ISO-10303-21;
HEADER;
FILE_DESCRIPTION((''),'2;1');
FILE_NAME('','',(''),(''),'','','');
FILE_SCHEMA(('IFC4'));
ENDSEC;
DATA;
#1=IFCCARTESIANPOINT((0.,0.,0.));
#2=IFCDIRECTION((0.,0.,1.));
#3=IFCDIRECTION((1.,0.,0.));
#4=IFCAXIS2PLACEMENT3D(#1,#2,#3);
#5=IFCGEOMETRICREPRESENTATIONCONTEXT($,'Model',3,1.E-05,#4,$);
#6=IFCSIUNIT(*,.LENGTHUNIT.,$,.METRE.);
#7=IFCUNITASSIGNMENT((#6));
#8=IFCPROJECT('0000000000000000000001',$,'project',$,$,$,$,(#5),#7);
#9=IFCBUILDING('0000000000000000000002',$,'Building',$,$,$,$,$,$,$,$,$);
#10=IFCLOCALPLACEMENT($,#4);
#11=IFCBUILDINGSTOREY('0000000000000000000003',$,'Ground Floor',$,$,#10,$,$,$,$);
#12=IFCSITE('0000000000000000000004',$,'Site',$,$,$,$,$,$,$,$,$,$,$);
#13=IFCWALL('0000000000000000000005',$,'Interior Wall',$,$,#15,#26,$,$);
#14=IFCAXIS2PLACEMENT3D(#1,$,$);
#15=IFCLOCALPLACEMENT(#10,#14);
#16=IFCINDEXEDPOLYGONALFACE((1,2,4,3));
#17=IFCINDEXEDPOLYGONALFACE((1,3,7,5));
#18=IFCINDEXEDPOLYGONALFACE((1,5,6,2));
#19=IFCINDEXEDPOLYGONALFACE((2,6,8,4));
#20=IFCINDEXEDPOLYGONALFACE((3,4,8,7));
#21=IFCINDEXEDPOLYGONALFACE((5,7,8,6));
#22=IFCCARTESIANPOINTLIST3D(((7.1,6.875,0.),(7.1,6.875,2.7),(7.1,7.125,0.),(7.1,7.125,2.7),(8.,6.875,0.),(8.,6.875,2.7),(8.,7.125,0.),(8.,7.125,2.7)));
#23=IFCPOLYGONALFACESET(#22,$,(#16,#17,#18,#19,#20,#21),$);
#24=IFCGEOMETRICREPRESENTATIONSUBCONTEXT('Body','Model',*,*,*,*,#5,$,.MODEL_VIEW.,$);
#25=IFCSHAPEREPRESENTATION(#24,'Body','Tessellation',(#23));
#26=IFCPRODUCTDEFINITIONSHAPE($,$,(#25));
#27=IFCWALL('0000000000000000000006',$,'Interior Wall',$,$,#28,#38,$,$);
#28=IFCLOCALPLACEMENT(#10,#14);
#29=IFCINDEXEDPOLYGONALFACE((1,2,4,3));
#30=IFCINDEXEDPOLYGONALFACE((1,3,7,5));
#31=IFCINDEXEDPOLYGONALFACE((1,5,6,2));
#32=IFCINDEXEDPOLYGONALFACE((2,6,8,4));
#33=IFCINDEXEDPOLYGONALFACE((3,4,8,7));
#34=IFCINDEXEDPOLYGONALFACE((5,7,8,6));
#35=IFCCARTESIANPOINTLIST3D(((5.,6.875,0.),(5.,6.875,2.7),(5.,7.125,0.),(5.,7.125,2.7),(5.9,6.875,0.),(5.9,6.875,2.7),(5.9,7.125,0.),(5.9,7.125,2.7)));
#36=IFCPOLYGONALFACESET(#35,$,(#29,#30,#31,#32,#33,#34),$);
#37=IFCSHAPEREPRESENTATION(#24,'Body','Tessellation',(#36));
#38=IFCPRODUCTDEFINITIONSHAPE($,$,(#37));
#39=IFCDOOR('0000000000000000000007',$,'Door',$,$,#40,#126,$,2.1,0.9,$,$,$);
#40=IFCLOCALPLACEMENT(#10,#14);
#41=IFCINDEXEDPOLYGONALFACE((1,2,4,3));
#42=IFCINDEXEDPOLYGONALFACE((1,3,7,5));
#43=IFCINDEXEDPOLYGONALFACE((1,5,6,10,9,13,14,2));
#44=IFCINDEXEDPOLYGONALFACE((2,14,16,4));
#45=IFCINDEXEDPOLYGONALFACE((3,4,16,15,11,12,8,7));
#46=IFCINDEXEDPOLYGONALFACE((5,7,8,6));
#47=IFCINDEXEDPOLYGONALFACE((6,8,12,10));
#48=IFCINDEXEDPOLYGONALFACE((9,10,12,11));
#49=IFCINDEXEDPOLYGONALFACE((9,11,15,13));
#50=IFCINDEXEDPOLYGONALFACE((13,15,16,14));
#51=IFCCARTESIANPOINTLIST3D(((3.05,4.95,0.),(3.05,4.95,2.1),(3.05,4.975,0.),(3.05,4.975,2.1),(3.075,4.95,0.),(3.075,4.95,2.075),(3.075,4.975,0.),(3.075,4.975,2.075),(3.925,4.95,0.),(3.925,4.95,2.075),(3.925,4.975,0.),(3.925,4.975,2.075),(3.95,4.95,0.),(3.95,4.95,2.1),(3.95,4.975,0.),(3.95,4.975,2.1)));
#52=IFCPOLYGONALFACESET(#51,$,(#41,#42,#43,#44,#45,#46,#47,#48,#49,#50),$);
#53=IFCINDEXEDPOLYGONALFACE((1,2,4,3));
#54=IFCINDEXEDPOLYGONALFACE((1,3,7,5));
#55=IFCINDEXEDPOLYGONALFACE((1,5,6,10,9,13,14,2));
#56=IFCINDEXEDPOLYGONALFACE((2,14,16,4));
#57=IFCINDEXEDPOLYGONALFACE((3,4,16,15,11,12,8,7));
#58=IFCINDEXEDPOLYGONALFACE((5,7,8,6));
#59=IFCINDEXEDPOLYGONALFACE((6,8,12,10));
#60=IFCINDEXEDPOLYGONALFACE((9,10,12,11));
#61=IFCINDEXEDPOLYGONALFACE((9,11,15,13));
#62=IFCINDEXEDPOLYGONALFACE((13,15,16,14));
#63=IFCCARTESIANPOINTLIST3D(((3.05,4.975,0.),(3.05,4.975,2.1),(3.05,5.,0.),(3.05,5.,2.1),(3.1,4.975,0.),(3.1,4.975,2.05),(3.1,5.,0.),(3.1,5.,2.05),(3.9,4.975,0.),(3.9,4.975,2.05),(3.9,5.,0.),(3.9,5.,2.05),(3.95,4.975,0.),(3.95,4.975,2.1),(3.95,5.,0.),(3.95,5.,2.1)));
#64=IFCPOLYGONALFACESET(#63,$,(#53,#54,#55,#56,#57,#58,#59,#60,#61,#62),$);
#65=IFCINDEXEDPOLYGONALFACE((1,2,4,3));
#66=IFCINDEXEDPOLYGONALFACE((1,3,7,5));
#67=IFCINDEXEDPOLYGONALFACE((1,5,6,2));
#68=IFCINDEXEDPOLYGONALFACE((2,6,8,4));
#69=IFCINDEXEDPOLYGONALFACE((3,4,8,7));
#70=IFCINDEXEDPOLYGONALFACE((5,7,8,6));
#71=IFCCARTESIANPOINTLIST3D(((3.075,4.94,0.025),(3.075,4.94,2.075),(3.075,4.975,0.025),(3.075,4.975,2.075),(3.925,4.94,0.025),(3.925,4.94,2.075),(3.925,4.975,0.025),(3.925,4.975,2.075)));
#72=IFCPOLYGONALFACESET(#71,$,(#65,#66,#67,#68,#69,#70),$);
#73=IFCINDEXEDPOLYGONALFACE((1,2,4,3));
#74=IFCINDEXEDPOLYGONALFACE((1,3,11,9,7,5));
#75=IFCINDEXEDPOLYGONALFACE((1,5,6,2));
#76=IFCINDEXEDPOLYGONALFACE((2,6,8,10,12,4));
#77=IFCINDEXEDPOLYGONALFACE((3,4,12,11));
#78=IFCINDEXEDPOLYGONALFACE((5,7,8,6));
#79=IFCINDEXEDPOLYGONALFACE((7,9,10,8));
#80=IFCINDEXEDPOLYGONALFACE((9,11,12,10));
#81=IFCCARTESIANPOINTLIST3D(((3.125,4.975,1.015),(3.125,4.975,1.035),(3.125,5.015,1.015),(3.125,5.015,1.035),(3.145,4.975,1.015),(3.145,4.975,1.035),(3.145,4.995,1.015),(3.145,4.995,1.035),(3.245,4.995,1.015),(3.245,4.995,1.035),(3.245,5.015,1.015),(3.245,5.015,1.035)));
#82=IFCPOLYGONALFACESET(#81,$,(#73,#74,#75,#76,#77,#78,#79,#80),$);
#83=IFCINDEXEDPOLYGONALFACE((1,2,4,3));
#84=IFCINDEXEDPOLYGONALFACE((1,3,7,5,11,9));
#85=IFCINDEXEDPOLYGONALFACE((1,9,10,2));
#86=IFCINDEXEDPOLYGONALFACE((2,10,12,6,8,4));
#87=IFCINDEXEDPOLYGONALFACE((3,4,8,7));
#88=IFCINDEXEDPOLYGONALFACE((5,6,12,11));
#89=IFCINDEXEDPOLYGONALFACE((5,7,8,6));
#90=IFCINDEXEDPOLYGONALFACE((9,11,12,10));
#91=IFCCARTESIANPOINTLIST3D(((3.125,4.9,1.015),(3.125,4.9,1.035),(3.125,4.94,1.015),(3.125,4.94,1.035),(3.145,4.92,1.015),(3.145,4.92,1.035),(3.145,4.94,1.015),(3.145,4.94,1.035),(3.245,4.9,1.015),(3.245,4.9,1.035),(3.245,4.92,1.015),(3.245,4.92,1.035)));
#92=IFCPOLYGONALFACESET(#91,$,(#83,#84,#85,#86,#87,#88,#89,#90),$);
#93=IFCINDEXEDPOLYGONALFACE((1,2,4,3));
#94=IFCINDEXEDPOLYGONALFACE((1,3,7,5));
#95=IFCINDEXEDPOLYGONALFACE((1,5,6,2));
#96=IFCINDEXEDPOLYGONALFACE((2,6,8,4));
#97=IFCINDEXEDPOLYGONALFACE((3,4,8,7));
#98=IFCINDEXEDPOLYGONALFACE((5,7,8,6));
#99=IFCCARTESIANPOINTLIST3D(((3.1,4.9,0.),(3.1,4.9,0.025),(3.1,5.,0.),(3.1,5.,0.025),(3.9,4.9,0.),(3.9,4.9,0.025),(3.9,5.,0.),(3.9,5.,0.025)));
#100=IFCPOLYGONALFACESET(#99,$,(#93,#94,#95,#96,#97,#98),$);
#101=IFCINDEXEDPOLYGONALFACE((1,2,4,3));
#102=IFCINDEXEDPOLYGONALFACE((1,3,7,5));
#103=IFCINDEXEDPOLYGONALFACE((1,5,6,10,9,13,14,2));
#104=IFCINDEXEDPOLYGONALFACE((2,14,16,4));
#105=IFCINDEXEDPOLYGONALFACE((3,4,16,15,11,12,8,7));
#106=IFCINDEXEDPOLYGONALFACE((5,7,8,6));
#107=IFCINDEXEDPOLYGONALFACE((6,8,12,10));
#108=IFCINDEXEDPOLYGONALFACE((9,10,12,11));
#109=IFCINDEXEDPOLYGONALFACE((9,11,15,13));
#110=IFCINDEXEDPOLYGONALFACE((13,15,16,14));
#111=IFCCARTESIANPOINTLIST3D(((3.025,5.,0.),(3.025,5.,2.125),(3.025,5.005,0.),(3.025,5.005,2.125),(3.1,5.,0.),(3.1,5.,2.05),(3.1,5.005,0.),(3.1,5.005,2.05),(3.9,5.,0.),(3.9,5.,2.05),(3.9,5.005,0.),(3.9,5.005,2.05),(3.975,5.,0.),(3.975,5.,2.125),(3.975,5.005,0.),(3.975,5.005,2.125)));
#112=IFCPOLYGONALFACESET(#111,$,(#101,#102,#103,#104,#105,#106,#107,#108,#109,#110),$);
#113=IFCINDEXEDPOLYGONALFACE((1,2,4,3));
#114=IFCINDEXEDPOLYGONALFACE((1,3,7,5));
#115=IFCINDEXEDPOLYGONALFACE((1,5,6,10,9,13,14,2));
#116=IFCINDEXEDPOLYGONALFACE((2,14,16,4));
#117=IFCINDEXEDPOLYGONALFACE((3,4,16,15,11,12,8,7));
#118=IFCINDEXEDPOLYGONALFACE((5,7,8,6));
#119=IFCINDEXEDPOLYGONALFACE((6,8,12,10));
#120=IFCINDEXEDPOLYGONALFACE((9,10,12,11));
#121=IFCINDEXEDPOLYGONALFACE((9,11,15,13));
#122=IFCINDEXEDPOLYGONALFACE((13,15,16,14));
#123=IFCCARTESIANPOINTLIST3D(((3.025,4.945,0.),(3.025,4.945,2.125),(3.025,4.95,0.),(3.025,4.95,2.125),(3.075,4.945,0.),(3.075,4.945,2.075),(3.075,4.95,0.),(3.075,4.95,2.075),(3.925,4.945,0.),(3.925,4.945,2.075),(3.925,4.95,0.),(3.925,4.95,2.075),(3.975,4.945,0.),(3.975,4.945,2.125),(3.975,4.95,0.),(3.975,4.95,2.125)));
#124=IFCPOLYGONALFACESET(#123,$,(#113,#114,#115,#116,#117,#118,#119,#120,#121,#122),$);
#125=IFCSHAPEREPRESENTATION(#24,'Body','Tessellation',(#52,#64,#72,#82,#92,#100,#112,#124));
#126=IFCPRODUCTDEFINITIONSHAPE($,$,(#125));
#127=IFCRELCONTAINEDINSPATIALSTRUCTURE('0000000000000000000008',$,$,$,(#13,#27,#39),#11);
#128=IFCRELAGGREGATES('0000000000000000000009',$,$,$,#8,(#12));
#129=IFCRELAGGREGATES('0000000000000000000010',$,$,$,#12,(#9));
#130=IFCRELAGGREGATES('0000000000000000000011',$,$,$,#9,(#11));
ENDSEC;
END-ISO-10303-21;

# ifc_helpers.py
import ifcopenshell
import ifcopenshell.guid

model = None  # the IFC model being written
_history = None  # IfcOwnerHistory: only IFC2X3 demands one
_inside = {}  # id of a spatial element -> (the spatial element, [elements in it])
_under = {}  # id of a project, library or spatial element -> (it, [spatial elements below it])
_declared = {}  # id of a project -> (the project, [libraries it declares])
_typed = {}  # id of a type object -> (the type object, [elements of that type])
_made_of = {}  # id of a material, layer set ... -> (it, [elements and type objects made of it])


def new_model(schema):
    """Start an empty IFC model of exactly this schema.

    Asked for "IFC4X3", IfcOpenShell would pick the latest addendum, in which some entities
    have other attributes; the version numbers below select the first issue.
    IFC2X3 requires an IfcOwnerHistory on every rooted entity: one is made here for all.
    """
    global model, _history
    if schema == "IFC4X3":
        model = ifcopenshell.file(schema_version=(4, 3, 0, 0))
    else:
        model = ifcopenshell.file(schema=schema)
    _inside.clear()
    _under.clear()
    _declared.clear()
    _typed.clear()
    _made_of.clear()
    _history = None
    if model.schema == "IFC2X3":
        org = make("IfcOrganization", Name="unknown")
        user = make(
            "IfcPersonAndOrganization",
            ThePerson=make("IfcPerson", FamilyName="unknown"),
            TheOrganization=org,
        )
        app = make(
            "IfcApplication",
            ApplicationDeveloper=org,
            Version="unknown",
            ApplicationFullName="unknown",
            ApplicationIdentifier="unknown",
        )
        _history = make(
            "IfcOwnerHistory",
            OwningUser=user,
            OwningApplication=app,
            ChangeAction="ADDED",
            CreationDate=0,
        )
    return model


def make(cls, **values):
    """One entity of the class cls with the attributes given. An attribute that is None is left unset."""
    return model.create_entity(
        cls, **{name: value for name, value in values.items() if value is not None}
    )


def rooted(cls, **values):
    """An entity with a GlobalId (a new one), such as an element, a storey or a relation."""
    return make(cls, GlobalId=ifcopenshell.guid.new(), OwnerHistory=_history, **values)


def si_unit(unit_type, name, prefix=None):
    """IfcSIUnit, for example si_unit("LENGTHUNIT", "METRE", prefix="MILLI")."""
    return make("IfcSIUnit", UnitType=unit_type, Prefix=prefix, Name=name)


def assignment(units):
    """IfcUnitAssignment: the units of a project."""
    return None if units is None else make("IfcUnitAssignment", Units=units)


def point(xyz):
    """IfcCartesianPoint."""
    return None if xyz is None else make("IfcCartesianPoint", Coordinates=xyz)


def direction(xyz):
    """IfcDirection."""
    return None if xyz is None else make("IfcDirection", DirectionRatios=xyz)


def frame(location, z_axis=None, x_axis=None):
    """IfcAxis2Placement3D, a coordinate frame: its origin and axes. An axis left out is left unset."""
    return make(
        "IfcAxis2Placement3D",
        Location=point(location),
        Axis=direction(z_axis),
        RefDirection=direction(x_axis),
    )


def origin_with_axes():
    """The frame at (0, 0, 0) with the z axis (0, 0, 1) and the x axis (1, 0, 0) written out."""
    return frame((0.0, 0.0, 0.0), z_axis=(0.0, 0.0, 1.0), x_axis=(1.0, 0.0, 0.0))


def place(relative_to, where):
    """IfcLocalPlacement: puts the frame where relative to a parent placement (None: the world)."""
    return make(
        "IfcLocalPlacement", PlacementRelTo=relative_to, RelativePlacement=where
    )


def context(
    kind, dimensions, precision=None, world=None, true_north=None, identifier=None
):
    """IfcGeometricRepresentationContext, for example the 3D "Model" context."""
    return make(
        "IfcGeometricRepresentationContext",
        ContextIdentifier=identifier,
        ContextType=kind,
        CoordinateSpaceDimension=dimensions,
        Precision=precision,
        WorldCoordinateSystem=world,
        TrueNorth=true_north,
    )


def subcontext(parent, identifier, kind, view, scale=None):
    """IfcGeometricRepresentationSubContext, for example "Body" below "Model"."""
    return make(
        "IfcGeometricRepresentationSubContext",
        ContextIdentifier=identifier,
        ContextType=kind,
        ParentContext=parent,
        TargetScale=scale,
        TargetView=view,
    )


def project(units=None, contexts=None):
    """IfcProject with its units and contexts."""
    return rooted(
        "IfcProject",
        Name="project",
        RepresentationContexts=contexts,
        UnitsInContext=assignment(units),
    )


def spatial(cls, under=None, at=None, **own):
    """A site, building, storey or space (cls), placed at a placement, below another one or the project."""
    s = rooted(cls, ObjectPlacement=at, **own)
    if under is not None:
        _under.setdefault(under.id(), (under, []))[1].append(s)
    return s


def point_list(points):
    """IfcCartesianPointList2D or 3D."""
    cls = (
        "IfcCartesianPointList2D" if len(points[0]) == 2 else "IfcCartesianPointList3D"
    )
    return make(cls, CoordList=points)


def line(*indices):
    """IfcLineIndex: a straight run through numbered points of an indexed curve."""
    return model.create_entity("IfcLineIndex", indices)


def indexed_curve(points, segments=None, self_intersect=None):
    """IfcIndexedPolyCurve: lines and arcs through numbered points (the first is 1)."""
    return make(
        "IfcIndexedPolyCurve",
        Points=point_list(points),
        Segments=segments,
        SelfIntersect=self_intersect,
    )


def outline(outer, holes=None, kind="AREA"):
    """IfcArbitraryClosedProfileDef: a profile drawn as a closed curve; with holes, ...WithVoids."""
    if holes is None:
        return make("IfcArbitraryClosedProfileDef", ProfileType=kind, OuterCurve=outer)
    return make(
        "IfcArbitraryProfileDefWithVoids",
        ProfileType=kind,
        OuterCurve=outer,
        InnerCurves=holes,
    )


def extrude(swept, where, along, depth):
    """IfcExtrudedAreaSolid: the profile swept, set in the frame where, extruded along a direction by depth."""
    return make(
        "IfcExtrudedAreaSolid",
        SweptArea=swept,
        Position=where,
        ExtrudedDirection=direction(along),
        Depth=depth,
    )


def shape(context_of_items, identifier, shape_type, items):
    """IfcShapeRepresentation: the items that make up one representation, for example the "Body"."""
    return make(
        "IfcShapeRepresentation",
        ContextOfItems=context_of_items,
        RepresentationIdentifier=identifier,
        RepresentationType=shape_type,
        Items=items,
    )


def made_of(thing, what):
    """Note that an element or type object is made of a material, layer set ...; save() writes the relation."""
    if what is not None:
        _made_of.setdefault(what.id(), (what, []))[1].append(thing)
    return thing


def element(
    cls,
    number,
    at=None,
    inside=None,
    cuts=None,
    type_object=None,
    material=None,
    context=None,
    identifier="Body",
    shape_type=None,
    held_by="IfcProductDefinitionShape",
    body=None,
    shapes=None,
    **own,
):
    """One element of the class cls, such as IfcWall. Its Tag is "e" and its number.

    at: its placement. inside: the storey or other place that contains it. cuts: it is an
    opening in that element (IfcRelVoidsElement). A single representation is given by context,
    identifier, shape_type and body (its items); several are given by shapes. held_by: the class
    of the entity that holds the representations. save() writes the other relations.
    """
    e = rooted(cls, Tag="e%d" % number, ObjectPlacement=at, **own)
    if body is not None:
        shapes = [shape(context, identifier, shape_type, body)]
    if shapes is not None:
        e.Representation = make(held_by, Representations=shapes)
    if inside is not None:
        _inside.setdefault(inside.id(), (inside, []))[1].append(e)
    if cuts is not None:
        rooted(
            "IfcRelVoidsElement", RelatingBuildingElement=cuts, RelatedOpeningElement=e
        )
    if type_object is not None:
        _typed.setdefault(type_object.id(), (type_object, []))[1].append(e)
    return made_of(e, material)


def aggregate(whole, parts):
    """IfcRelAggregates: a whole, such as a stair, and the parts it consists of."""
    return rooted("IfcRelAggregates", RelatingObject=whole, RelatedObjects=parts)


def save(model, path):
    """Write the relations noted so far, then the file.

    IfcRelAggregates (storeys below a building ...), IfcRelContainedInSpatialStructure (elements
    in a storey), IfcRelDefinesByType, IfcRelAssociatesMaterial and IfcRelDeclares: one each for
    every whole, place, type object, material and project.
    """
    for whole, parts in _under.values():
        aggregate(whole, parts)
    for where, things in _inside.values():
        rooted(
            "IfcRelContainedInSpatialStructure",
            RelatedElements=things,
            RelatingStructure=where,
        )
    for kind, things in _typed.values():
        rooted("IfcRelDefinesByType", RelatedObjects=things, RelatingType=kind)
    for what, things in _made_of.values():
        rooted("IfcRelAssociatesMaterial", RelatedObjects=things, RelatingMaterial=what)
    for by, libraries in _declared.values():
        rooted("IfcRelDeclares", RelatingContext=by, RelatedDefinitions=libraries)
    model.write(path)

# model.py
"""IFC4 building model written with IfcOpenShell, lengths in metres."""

from ifc_helpers import new_model, si_unit, frame, origin_with_axes, place, context, subcontext, project, spatial, line, indexed_curve, outline, extrude, element, save


model = new_model("IFC4")

# Units and contexts
model_context = context("Model", 3, precision=1e-05, world=origin_with_axes())
body_context = subcontext(model_context, "Body", "Model", "MODEL_VIEW")
ifc_project = project(units=[si_unit("LENGTHUNIT", "METRE")], contexts=[model_context])

# Site, building, storey
site = spatial("IfcSite", under=ifc_project, Name="Site")
building = spatial("IfcBuilding", under=site, Name="Building")
storey_placement = place(None, origin_with_axes())
storey = spatial("IfcBuildingStorey", under=building, at=storey_placement, Name="Ground Floor")

# Walls
for number, where, z_axis, x_axis, name in (
    (1, (8.0, 7.0, 0.0), (0.0, 0.0, 1.0), (-1.0, 0.0, 0.0), "Interior Wall"),
    (2, (5.9, 7.0, 0.0), (0.0, 0.0, 1.0), (-1.0, 0.0, 0.0), "Interior Wall"),
):
    element("IfcWall", number, at=place(storey_placement, frame(where, z_axis=z_axis, x_axis=x_axis)), inside=storey, Name=name, context=body_context, shape_type="SweptSolid", body=[
        extrude(outline(indexed_curve([(0.0, 0.0), (0.0, 0.25), (0.9, 0.25), (0.9, 0.0), (0.0, 0.0)], self_intersect=False)), frame((0.0, -0.125, 0.0), z_axis=(0.0, 0.0, 1.0), x_axis=(1.0, 0.0, 0.0)), (0.0, 0.0, 1.0), 2.7),
    ])

# Door
door_1_placement = place(storey_placement, frame((3.95, 5.0, 0.0), z_axis=(0.0, 0.0, 1.0), x_axis=(-1.0, 0.0, 0.0)))
element("IfcDoor", 3, at=door_1_placement, inside=storey, Name="Door", OverallHeight=2.1, OverallWidth=0.9, context=body_context, shape_type="SweptSolid", body=[
    extrude(outline(indexed_curve([(0.0, 0.0), (0.0, 2.1), (0.9, 2.1), (0.9, 0.0), (0.875, 0.0), (0.875, 2.075), (0.025, 2.075), (0.025, 0.0)], segments=[line(1, 2, 3, 4, 5, 6, 7, 8, 1)])), frame((0.0, 0.025, 0.0), z_axis=(0.0, -1.0, 0.0), x_axis=(1.0, 0.0, 0.0)), (0.0, 0.0, -1.0), 0.025),
    extrude(outline(indexed_curve([(0.0, 0.0), (0.0, 2.1), (0.9, 2.1), (0.9, 0.0), (0.85, 0.0), (0.85, 2.05), (0.05, 2.05), (0.05, 0.0)], segments=[line(1, 2, 3, 4, 5, 6, 7, 8, 1)])), frame((0.0, 0.0, 0.0), z_axis=(0.0, -1.0, 0.0), x_axis=(1.0, 0.0, 0.0)), (0.0, 0.0, -1.0), 0.025),
    extrude(outline(indexed_curve([(0.0, 0.0), (0.85, 0.0), (0.85, 0.035), (0.0, 0.035)], segments=[line(1, 2, 3, 4, 1)])), frame((0.025, 0.025, 0.025), z_axis=(0.0, 0.0, 1.0), x_axis=(1.0, 0.0, 0.0)), (0.0, 0.0, 1.0), 2.05),
    extrude(outline(indexed_curve([(0.0, 0.0), (0.0, -0.04), (-0.12, -0.04), (-0.12, -0.02), (-0.02, -0.02), (-0.02, 0.0)], segments=[line(1, 2, 3, 4, 5, 6, 1)])), frame((0.825, 0.025, 1.015), z_axis=(0.0, 0.0, 1.0), x_axis=(1.0, 0.0, 0.0)), (0.0, 0.0, 1.0), 0.02),
    extrude(outline(indexed_curve([(0.0, 0.0), (0.0, 0.04), (-0.12, 0.04), (-0.12, 0.02), (-0.02, 0.02), (-0.02, 0.0)], segments=[line(1, 2, 3, 4, 5, 6, 1)])), frame((0.825, 0.06, 1.015), z_axis=(0.0, 0.0, 1.0), x_axis=(1.0, 0.0, 0.0)), (0.0, 0.0, 1.0), 0.02),
    extrude(outline(indexed_curve([(0.0, 0.0), (0.8, 0.0), (0.8, 0.1), (0.0, 0.1)], segments=[line(1, 2, 3, 4, 1)])), frame((0.05, 0.0, 0.0), z_axis=(0.0, 0.0, 1.0), x_axis=(1.0, 0.0, 0.0)), (0.0, 0.0, 1.0), 0.025),
    extrude(outline(indexed_curve([(0.0, 0.0), (0.0, 2.125), (0.95, 2.125), (0.95, 0.0), (0.875, 0.0), (0.875, 2.05), (0.075, 2.05), (0.075, 0.0)], segments=[line(1, 2, 3, 4, 5, 6, 7, 8, 1)])), frame((-0.025, -0.005, 0.0), z_axis=(0.0, -1.0, 0.0), x_axis=(1.0, 0.0, 0.0)), (0.0, 0.0, -1.0), 0.005),
    extrude(outline(indexed_curve([(0.0, 0.0), (0.0, 2.125), (0.95, 2.125), (0.95, 0.0), (0.9, 0.0), (0.9, 2.075), (0.05, 2.075), (0.05, 0.0)], segments=[line(1, 2, 3, 4, 5, 6, 7, 8, 1)])), frame((-0.025, 0.05, 0.0), z_axis=(0.0, -1.0, 0.0), x_axis=(1.0, 0.0, 0.0)), (0.0, 0.0, -1.0), 0.005),
])

save(model, "model.ifc")
